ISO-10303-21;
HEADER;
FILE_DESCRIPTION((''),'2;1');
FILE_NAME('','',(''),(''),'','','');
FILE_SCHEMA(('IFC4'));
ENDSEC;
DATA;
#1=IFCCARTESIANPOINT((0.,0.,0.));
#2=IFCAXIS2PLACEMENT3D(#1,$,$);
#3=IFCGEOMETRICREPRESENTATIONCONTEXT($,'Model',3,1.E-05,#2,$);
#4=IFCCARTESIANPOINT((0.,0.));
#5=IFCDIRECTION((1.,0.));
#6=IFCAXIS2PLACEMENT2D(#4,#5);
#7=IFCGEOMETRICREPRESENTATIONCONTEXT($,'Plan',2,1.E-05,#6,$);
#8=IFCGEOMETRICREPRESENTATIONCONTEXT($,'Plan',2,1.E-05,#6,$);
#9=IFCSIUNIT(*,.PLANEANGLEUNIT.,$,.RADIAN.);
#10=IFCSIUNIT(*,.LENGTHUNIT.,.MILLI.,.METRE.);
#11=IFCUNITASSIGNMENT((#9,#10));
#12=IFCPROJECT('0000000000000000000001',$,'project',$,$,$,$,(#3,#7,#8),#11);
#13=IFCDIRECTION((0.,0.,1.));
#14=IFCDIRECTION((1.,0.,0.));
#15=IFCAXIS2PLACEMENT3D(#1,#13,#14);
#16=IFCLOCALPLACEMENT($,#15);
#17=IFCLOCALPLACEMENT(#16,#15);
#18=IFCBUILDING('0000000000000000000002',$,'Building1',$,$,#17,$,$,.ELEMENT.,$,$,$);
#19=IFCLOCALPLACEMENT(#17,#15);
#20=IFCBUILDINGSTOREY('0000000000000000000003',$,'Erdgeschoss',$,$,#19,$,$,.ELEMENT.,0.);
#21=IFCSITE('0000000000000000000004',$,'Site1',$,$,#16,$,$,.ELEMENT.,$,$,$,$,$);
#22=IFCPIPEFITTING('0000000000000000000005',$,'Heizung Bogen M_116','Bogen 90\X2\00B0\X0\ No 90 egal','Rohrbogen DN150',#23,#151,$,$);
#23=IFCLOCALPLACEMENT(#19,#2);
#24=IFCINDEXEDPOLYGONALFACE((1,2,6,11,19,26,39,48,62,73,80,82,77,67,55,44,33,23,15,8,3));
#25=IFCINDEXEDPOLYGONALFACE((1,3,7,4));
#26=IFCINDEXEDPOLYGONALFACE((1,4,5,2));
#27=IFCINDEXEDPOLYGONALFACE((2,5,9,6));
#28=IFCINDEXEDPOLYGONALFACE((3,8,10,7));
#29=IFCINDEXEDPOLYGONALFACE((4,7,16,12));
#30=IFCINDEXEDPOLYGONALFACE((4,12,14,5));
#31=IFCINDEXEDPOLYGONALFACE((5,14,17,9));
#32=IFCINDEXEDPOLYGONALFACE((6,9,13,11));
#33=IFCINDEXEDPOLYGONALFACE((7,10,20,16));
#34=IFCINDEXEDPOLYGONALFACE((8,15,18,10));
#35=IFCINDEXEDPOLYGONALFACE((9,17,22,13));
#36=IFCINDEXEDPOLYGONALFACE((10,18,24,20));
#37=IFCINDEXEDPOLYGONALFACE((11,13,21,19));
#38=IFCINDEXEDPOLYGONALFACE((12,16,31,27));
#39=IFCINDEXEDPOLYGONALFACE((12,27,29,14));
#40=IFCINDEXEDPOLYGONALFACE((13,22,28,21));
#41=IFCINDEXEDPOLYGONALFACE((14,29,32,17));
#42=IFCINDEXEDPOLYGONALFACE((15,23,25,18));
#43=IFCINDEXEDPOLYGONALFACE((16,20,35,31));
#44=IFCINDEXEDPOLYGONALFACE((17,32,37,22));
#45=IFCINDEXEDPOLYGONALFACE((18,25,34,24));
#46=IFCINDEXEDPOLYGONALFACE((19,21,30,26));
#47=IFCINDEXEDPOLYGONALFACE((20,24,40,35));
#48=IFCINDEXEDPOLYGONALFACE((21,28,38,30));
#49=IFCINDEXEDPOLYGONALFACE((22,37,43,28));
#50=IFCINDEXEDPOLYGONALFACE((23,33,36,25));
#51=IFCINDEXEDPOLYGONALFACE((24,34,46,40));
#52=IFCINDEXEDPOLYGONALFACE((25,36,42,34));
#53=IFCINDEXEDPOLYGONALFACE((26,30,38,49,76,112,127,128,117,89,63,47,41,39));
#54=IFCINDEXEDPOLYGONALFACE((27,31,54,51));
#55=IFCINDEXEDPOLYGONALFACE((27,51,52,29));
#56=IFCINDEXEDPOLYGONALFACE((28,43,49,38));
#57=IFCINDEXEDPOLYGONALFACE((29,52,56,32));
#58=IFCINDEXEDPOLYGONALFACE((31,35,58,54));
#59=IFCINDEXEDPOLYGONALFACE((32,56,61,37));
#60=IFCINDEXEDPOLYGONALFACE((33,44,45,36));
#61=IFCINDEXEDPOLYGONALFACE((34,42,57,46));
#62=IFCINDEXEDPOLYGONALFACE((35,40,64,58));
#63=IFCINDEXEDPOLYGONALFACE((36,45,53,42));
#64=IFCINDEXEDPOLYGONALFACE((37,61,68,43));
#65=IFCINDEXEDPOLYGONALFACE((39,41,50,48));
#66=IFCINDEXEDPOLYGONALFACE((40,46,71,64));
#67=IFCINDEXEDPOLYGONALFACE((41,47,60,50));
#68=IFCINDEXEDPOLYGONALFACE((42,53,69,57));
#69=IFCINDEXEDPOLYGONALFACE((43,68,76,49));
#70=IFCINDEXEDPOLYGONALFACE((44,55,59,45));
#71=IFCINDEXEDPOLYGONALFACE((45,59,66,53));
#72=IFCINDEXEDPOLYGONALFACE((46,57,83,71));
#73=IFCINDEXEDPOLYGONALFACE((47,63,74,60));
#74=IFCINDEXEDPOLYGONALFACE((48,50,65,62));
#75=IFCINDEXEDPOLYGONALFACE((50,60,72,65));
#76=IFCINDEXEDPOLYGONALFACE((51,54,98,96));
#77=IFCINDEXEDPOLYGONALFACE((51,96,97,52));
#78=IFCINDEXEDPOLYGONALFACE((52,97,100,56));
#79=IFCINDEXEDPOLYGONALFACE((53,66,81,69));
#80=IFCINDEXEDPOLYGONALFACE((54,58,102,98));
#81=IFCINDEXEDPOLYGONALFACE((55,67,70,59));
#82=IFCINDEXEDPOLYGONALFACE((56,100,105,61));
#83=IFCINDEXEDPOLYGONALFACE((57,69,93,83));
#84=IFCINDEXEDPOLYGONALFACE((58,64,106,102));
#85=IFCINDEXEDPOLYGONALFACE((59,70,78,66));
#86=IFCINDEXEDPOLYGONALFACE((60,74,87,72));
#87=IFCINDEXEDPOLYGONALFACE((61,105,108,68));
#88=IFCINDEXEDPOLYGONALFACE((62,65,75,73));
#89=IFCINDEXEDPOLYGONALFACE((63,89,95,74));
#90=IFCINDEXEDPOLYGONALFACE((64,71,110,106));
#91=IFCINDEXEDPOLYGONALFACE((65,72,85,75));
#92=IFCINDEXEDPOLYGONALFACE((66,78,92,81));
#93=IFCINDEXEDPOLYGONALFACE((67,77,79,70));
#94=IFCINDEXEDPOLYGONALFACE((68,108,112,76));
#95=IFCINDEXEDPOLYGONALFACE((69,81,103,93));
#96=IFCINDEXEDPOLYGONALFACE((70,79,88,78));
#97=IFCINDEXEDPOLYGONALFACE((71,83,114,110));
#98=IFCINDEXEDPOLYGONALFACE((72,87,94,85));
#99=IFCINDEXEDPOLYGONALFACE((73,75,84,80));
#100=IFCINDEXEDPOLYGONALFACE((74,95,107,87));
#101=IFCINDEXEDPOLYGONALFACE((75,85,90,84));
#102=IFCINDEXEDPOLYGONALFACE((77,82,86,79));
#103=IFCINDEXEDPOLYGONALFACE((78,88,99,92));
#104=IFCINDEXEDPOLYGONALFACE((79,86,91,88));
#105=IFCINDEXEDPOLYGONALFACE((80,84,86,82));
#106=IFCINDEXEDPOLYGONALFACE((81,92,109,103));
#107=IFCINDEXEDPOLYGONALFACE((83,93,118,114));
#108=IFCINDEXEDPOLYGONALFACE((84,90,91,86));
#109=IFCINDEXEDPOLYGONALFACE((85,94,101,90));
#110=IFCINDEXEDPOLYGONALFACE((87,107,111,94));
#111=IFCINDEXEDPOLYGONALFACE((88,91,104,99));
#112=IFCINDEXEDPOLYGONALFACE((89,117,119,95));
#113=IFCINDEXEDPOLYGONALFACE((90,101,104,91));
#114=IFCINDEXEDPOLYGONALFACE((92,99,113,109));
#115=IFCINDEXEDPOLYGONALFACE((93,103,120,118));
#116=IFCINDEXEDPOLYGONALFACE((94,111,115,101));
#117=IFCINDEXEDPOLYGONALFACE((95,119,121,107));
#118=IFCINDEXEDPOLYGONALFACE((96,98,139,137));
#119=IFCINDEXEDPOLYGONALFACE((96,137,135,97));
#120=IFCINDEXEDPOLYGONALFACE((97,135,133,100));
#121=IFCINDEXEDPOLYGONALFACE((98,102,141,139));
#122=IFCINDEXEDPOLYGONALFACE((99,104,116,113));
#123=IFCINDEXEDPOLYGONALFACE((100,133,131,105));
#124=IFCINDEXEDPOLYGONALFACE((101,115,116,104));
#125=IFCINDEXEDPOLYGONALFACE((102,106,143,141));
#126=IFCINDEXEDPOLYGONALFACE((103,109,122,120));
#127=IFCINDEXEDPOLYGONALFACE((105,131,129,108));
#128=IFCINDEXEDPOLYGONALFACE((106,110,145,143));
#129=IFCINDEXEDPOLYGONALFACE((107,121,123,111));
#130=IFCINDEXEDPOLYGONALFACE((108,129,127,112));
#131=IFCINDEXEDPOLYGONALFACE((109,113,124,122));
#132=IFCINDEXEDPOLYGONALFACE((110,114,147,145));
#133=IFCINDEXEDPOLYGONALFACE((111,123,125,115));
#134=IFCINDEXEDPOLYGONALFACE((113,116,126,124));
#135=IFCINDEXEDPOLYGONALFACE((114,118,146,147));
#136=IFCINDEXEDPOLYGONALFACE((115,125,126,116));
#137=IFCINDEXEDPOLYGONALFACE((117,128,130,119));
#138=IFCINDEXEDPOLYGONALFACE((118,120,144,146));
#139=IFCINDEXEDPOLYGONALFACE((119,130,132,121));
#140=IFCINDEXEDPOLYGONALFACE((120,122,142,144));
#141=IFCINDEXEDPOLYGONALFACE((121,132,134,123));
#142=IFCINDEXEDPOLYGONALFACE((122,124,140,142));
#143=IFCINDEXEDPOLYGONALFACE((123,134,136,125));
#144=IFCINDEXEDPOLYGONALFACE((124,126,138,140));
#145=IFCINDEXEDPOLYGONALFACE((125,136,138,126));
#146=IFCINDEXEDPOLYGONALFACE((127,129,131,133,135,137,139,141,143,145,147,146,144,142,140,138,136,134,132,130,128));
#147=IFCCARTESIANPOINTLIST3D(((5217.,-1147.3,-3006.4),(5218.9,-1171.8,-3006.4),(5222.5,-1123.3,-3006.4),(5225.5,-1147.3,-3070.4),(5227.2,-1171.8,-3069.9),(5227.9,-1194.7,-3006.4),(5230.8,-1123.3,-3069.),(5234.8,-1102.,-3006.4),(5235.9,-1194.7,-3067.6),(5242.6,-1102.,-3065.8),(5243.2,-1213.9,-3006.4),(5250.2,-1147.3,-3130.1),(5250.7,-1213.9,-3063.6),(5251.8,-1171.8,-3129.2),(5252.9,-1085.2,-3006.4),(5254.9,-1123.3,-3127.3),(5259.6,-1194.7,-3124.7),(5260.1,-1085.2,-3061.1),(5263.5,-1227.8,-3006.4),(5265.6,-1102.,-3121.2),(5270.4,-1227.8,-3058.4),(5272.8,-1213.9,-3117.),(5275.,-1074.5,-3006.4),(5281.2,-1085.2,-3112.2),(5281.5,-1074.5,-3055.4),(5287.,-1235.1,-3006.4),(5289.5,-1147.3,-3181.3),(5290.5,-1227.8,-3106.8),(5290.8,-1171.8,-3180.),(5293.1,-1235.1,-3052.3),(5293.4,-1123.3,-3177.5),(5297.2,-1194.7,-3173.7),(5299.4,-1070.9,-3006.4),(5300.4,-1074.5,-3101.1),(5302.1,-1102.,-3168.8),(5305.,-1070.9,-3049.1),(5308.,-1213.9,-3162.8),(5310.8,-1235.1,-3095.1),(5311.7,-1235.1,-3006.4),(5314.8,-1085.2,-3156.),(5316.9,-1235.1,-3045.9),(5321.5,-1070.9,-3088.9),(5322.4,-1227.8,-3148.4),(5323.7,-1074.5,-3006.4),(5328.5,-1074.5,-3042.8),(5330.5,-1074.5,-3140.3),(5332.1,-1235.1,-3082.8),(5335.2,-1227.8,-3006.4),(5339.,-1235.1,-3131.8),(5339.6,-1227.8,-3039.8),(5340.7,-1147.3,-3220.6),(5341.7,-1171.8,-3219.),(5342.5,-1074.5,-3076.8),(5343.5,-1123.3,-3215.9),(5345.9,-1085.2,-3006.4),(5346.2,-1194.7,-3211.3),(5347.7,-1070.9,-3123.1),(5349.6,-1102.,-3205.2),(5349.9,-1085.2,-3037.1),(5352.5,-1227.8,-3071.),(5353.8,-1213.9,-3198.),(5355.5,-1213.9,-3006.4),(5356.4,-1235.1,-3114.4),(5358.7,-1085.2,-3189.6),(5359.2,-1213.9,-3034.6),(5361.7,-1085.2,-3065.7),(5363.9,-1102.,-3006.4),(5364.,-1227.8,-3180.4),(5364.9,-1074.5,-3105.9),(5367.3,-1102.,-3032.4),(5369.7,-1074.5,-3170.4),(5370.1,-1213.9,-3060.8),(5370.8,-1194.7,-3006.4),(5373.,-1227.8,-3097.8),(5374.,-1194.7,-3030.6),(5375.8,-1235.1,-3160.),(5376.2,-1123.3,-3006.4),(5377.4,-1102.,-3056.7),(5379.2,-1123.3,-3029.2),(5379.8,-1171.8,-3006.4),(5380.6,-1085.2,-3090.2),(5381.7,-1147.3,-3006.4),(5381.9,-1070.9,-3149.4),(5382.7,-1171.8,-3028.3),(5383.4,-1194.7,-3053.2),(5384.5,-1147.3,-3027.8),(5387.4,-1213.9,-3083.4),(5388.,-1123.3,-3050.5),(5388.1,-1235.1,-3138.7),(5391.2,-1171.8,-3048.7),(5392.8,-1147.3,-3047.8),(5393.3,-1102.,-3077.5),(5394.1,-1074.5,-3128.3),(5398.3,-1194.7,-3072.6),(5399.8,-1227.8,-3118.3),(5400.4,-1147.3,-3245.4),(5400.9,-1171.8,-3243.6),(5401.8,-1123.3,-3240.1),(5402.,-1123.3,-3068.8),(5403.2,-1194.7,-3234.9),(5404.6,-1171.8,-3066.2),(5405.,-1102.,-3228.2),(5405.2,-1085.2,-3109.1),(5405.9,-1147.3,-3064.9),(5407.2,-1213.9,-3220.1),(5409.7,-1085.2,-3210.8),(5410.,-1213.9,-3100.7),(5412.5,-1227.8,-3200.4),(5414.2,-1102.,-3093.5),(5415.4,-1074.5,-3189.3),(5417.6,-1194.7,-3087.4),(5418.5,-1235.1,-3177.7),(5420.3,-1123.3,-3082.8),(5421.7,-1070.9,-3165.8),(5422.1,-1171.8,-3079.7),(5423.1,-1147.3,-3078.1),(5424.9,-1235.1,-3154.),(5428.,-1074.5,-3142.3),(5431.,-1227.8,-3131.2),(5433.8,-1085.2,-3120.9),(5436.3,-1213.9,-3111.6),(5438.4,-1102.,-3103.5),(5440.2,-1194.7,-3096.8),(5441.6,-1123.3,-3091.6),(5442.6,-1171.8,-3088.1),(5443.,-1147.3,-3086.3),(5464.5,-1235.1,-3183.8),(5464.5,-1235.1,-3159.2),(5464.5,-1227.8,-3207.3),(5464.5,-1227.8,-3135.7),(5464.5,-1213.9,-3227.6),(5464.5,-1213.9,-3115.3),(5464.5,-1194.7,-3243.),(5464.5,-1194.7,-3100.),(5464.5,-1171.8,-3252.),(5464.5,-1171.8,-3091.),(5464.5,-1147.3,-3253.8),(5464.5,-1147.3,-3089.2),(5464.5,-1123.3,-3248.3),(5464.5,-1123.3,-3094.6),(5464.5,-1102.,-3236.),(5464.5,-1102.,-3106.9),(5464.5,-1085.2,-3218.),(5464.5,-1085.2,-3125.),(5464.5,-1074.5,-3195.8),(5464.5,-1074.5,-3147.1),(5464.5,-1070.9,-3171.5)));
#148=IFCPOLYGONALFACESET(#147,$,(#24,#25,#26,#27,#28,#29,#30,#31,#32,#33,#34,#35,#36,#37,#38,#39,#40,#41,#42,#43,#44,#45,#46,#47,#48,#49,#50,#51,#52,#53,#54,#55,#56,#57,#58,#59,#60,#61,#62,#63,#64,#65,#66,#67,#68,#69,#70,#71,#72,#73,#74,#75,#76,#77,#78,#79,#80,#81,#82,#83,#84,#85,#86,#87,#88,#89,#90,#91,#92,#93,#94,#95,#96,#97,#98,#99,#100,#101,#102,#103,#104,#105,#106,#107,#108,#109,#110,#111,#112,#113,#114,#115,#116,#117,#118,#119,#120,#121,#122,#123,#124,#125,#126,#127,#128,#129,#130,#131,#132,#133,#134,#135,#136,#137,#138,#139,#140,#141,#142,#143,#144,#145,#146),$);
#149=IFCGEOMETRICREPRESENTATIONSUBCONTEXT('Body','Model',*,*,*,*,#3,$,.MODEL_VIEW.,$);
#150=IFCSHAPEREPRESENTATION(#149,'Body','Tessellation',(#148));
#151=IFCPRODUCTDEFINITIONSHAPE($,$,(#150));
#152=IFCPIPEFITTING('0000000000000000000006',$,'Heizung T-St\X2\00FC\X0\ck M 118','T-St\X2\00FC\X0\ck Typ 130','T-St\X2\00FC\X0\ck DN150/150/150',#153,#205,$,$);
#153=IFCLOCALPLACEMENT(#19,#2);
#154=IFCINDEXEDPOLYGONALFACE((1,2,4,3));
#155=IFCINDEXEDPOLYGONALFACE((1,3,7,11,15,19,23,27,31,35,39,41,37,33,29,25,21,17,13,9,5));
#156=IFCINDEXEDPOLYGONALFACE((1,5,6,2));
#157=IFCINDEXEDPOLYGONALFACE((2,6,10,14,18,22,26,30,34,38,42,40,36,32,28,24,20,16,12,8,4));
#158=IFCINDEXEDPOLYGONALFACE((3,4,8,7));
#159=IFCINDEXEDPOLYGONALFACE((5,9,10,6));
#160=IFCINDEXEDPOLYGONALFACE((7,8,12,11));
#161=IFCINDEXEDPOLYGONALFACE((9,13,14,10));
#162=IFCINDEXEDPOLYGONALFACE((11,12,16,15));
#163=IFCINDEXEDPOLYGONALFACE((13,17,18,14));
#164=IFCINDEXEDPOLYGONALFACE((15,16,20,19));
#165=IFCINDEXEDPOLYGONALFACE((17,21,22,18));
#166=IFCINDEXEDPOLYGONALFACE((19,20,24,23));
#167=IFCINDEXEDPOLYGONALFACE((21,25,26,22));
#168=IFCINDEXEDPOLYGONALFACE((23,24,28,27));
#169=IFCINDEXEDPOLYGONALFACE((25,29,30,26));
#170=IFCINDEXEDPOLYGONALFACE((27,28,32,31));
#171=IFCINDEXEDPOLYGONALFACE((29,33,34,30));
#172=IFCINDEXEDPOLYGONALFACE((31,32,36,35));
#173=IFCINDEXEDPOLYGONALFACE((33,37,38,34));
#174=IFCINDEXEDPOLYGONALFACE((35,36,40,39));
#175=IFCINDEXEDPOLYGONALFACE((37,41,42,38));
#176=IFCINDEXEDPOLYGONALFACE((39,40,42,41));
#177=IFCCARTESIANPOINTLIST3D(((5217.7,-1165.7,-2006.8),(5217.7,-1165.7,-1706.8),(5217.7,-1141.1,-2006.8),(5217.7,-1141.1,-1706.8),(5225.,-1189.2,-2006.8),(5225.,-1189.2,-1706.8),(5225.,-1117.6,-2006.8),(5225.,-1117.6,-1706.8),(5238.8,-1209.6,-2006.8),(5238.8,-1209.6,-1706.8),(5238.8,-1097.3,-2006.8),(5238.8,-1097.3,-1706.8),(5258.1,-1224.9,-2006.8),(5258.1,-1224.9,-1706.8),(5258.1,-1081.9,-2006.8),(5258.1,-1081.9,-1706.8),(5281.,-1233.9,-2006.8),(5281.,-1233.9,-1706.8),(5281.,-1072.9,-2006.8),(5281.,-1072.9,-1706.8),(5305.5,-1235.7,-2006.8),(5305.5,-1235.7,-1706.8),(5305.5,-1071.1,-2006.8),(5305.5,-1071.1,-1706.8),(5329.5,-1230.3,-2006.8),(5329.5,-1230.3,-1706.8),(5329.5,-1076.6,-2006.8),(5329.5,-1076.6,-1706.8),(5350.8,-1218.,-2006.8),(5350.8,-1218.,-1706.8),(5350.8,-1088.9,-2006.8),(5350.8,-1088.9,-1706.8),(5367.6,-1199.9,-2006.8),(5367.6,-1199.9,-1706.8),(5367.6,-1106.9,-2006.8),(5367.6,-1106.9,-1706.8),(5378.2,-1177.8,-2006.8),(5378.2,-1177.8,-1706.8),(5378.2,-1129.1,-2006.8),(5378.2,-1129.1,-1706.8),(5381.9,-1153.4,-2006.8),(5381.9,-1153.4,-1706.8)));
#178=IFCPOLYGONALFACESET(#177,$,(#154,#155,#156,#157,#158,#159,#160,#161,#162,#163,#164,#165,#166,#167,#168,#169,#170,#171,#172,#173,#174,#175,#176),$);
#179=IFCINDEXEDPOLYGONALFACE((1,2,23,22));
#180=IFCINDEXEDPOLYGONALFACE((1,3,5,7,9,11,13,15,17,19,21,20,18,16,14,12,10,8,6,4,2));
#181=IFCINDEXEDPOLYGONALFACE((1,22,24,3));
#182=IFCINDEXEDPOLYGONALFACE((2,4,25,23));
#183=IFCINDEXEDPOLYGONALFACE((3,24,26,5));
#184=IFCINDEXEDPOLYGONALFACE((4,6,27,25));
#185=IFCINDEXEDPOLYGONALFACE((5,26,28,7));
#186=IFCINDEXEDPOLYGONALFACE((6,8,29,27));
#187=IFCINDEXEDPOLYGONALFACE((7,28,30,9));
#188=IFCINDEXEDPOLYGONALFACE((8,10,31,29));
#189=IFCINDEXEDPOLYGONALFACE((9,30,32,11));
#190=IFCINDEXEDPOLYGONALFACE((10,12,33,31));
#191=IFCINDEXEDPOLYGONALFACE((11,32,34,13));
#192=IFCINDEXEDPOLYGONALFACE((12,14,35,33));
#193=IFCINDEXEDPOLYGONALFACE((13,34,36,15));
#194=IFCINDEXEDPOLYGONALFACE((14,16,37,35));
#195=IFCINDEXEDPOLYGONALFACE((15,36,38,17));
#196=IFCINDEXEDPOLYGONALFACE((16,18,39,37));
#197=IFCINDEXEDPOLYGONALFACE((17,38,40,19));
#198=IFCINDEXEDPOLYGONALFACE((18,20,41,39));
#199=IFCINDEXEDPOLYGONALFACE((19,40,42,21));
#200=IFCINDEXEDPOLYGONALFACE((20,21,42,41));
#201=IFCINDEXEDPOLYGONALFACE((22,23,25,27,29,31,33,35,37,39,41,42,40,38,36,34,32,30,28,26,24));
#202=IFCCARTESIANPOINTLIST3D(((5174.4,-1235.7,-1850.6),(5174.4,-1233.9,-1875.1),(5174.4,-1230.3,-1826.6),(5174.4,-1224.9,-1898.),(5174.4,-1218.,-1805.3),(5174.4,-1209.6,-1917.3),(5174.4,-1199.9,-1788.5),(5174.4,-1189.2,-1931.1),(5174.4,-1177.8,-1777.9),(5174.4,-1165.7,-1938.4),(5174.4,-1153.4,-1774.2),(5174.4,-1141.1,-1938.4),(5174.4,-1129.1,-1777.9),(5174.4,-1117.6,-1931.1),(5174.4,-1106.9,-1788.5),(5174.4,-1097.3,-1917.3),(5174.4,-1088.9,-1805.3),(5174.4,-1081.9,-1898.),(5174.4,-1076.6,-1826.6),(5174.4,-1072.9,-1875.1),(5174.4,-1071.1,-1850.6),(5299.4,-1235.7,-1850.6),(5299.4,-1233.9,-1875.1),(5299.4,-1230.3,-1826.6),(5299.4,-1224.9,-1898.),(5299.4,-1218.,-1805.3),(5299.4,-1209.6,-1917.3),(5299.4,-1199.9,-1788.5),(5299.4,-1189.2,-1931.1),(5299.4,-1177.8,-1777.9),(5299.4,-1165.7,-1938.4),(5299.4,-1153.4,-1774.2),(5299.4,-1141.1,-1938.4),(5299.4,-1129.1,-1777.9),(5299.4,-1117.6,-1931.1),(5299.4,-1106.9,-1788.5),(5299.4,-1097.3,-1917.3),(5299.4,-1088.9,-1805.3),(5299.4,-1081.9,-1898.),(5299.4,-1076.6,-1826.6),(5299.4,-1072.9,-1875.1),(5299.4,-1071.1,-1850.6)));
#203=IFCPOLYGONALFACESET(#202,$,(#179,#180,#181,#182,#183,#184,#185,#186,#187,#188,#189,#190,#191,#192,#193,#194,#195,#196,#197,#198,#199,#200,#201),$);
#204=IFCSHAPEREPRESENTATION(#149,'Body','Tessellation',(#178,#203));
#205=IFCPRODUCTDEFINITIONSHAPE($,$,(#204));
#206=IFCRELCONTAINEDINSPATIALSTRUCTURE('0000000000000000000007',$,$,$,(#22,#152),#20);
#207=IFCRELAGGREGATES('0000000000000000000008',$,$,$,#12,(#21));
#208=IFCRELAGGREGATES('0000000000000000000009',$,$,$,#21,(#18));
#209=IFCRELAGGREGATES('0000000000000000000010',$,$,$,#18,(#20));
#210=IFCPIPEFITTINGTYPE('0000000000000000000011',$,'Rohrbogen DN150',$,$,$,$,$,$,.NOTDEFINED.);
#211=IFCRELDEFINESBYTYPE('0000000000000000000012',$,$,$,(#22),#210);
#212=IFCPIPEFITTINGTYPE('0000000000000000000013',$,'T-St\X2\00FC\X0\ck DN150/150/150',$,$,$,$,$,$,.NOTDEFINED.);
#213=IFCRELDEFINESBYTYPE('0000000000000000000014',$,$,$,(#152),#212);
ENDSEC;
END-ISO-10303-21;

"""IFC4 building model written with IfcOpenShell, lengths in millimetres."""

from ifc_helpers import new_model, entity, si_unit, frame, origin, origin_with_axes, origin_2d_with_axis, place, context, subcontext, project, spatial, circle, extrude, source, transform, mapped, type_object, element, save


model = new_model("IFC4")

# Units and contexts
model_context = context("Model", 3, precision=1e-05, world=origin())
plan_context_1 = context("Plan", 2, precision=1e-05, world=origin_2d_with_axis())
plan_context_2 = context("Plan", 2, precision=1e-05, world=origin_2d_with_axis())
body_context = subcontext(model_context, "Body", "Model", "MODEL_VIEW")
ifc_project = project(units=[si_unit("PLANEANGLEUNIT", "RADIAN"), si_unit("LENGTHUNIT", "METRE", prefix="MILLI")], contexts=[model_context, plan_context_1, plan_context_2])

# Site, building, storey
site_placement = place(None, origin_with_axes())
site = spatial("IfcSite", under=ifc_project, at=site_placement, Name="Site1", CompositionType="ELEMENT")
building_placement = place(site_placement, origin_with_axes())
building = spatial("IfcBuilding", under=site, at=building_placement, Name="Building1", CompositionType="ELEMENT")
storey_placement = place(building_placement, origin_with_axes())
storey = spatial("IfcBuildingStorey", under=building, at=storey_placement, Name="Erdgeschoss", CompositionType="ELEMENT", Elevation=0.0)

# Pipe fittings
pipe_fitting_type_1 = type_object("IfcPipeFittingType", Name="Rohrbogen DN150", PredefinedType="NOTDEFINED")
shared_shape_1 = source(origin_with_axes(), body_context, "Body", "SolidModel", [
    entity("IfcRevolvedAreaSolid", entity("IfcCircleProfileDef", "AREA", None, entity("IfcAxis2Placement2D", entity("IfcCartesianPoint", [0.0, 0.0]), entity("IfcDirection", [1.0, 0.0])), 82.5), entity("IfcAxis2Placement3D", entity("IfcCartesianPoint", [123.8, -41.3, 0.0]), entity("IfcDirection", [-1.0, 0.0, 0.0]), entity("IfcDirection", [0.0, 0.0, 1.0])), entity("IfcAxis1Placement", entity("IfcCartesianPoint", [0.0, 165.1, 0.0]), entity("IfcDirection", [-1.0, 0.0, 0.0])), 1.570796),
])
pipe_fitting_1_placement = place(storey_placement, frame((5340.6, -1153.4, -3130.2), z_axis=(0.0, 0.0, 1.0), x_axis=(1.0, 0.0, 0.0)))
element("IfcPipeFitting", 1, at=pipe_fitting_1_placement, inside=storey, type_object=pipe_fitting_type_1, Name="Heizung Bogen M_116", Description="Bogen 90° No 90 egal", ObjectType="Rohrbogen DN150", context=body_context, shape_type="MappedRepresentation", body=[
    mapped(shared_shape_1, transform((0.0, 0.0, 0.0), x_axis=(0.0, 0.0, 1.0), y_axis=(1.0, 0.0, 0.0), z_axis=(0.0, 1.0, 0.0), scale=1.0)),
])
pipe_fitting_type_2 = type_object("IfcPipeFittingType", Name="T-Stück DN150/150/150", PredefinedType="NOTDEFINED")
pipe_fitting_2_placement = place(storey_placement, frame((5277.8, -1153.4, -1856.8), z_axis=(0.0, 0.0, 1.0), x_axis=(1.0, 0.0, 0.0)))
element("IfcPipeFitting", 2, at=pipe_fitting_2_placement, inside=storey, type_object=pipe_fitting_type_2, Name="Heizung T-Stück M 118", Description="T-Stück Typ 130", ObjectType="T-Stück DN150/150/150", context=body_context, shape_type="SolidModel", body=[
    extrude(circle(Radius=82.5, at=origin_2d_with_axis()), frame((21.6, 0.0, 150.0), z_axis=(0.0, 0.0, -1.0), x_axis=(1.0, 0.0, 0.0)), (0.0, 0.0, 1.0), 300.0),
    extrude(circle(Radius=82.5, at=origin_2d_with_axis()), frame((21.6, 0.0, 0.0), z_axis=(-1.0, 0.0, 0.0), x_axis=(0.0, 0.0, 1.0)), (0.0, 0.0, 1.0), 125.0),
])

save(model, "model.ifc")
